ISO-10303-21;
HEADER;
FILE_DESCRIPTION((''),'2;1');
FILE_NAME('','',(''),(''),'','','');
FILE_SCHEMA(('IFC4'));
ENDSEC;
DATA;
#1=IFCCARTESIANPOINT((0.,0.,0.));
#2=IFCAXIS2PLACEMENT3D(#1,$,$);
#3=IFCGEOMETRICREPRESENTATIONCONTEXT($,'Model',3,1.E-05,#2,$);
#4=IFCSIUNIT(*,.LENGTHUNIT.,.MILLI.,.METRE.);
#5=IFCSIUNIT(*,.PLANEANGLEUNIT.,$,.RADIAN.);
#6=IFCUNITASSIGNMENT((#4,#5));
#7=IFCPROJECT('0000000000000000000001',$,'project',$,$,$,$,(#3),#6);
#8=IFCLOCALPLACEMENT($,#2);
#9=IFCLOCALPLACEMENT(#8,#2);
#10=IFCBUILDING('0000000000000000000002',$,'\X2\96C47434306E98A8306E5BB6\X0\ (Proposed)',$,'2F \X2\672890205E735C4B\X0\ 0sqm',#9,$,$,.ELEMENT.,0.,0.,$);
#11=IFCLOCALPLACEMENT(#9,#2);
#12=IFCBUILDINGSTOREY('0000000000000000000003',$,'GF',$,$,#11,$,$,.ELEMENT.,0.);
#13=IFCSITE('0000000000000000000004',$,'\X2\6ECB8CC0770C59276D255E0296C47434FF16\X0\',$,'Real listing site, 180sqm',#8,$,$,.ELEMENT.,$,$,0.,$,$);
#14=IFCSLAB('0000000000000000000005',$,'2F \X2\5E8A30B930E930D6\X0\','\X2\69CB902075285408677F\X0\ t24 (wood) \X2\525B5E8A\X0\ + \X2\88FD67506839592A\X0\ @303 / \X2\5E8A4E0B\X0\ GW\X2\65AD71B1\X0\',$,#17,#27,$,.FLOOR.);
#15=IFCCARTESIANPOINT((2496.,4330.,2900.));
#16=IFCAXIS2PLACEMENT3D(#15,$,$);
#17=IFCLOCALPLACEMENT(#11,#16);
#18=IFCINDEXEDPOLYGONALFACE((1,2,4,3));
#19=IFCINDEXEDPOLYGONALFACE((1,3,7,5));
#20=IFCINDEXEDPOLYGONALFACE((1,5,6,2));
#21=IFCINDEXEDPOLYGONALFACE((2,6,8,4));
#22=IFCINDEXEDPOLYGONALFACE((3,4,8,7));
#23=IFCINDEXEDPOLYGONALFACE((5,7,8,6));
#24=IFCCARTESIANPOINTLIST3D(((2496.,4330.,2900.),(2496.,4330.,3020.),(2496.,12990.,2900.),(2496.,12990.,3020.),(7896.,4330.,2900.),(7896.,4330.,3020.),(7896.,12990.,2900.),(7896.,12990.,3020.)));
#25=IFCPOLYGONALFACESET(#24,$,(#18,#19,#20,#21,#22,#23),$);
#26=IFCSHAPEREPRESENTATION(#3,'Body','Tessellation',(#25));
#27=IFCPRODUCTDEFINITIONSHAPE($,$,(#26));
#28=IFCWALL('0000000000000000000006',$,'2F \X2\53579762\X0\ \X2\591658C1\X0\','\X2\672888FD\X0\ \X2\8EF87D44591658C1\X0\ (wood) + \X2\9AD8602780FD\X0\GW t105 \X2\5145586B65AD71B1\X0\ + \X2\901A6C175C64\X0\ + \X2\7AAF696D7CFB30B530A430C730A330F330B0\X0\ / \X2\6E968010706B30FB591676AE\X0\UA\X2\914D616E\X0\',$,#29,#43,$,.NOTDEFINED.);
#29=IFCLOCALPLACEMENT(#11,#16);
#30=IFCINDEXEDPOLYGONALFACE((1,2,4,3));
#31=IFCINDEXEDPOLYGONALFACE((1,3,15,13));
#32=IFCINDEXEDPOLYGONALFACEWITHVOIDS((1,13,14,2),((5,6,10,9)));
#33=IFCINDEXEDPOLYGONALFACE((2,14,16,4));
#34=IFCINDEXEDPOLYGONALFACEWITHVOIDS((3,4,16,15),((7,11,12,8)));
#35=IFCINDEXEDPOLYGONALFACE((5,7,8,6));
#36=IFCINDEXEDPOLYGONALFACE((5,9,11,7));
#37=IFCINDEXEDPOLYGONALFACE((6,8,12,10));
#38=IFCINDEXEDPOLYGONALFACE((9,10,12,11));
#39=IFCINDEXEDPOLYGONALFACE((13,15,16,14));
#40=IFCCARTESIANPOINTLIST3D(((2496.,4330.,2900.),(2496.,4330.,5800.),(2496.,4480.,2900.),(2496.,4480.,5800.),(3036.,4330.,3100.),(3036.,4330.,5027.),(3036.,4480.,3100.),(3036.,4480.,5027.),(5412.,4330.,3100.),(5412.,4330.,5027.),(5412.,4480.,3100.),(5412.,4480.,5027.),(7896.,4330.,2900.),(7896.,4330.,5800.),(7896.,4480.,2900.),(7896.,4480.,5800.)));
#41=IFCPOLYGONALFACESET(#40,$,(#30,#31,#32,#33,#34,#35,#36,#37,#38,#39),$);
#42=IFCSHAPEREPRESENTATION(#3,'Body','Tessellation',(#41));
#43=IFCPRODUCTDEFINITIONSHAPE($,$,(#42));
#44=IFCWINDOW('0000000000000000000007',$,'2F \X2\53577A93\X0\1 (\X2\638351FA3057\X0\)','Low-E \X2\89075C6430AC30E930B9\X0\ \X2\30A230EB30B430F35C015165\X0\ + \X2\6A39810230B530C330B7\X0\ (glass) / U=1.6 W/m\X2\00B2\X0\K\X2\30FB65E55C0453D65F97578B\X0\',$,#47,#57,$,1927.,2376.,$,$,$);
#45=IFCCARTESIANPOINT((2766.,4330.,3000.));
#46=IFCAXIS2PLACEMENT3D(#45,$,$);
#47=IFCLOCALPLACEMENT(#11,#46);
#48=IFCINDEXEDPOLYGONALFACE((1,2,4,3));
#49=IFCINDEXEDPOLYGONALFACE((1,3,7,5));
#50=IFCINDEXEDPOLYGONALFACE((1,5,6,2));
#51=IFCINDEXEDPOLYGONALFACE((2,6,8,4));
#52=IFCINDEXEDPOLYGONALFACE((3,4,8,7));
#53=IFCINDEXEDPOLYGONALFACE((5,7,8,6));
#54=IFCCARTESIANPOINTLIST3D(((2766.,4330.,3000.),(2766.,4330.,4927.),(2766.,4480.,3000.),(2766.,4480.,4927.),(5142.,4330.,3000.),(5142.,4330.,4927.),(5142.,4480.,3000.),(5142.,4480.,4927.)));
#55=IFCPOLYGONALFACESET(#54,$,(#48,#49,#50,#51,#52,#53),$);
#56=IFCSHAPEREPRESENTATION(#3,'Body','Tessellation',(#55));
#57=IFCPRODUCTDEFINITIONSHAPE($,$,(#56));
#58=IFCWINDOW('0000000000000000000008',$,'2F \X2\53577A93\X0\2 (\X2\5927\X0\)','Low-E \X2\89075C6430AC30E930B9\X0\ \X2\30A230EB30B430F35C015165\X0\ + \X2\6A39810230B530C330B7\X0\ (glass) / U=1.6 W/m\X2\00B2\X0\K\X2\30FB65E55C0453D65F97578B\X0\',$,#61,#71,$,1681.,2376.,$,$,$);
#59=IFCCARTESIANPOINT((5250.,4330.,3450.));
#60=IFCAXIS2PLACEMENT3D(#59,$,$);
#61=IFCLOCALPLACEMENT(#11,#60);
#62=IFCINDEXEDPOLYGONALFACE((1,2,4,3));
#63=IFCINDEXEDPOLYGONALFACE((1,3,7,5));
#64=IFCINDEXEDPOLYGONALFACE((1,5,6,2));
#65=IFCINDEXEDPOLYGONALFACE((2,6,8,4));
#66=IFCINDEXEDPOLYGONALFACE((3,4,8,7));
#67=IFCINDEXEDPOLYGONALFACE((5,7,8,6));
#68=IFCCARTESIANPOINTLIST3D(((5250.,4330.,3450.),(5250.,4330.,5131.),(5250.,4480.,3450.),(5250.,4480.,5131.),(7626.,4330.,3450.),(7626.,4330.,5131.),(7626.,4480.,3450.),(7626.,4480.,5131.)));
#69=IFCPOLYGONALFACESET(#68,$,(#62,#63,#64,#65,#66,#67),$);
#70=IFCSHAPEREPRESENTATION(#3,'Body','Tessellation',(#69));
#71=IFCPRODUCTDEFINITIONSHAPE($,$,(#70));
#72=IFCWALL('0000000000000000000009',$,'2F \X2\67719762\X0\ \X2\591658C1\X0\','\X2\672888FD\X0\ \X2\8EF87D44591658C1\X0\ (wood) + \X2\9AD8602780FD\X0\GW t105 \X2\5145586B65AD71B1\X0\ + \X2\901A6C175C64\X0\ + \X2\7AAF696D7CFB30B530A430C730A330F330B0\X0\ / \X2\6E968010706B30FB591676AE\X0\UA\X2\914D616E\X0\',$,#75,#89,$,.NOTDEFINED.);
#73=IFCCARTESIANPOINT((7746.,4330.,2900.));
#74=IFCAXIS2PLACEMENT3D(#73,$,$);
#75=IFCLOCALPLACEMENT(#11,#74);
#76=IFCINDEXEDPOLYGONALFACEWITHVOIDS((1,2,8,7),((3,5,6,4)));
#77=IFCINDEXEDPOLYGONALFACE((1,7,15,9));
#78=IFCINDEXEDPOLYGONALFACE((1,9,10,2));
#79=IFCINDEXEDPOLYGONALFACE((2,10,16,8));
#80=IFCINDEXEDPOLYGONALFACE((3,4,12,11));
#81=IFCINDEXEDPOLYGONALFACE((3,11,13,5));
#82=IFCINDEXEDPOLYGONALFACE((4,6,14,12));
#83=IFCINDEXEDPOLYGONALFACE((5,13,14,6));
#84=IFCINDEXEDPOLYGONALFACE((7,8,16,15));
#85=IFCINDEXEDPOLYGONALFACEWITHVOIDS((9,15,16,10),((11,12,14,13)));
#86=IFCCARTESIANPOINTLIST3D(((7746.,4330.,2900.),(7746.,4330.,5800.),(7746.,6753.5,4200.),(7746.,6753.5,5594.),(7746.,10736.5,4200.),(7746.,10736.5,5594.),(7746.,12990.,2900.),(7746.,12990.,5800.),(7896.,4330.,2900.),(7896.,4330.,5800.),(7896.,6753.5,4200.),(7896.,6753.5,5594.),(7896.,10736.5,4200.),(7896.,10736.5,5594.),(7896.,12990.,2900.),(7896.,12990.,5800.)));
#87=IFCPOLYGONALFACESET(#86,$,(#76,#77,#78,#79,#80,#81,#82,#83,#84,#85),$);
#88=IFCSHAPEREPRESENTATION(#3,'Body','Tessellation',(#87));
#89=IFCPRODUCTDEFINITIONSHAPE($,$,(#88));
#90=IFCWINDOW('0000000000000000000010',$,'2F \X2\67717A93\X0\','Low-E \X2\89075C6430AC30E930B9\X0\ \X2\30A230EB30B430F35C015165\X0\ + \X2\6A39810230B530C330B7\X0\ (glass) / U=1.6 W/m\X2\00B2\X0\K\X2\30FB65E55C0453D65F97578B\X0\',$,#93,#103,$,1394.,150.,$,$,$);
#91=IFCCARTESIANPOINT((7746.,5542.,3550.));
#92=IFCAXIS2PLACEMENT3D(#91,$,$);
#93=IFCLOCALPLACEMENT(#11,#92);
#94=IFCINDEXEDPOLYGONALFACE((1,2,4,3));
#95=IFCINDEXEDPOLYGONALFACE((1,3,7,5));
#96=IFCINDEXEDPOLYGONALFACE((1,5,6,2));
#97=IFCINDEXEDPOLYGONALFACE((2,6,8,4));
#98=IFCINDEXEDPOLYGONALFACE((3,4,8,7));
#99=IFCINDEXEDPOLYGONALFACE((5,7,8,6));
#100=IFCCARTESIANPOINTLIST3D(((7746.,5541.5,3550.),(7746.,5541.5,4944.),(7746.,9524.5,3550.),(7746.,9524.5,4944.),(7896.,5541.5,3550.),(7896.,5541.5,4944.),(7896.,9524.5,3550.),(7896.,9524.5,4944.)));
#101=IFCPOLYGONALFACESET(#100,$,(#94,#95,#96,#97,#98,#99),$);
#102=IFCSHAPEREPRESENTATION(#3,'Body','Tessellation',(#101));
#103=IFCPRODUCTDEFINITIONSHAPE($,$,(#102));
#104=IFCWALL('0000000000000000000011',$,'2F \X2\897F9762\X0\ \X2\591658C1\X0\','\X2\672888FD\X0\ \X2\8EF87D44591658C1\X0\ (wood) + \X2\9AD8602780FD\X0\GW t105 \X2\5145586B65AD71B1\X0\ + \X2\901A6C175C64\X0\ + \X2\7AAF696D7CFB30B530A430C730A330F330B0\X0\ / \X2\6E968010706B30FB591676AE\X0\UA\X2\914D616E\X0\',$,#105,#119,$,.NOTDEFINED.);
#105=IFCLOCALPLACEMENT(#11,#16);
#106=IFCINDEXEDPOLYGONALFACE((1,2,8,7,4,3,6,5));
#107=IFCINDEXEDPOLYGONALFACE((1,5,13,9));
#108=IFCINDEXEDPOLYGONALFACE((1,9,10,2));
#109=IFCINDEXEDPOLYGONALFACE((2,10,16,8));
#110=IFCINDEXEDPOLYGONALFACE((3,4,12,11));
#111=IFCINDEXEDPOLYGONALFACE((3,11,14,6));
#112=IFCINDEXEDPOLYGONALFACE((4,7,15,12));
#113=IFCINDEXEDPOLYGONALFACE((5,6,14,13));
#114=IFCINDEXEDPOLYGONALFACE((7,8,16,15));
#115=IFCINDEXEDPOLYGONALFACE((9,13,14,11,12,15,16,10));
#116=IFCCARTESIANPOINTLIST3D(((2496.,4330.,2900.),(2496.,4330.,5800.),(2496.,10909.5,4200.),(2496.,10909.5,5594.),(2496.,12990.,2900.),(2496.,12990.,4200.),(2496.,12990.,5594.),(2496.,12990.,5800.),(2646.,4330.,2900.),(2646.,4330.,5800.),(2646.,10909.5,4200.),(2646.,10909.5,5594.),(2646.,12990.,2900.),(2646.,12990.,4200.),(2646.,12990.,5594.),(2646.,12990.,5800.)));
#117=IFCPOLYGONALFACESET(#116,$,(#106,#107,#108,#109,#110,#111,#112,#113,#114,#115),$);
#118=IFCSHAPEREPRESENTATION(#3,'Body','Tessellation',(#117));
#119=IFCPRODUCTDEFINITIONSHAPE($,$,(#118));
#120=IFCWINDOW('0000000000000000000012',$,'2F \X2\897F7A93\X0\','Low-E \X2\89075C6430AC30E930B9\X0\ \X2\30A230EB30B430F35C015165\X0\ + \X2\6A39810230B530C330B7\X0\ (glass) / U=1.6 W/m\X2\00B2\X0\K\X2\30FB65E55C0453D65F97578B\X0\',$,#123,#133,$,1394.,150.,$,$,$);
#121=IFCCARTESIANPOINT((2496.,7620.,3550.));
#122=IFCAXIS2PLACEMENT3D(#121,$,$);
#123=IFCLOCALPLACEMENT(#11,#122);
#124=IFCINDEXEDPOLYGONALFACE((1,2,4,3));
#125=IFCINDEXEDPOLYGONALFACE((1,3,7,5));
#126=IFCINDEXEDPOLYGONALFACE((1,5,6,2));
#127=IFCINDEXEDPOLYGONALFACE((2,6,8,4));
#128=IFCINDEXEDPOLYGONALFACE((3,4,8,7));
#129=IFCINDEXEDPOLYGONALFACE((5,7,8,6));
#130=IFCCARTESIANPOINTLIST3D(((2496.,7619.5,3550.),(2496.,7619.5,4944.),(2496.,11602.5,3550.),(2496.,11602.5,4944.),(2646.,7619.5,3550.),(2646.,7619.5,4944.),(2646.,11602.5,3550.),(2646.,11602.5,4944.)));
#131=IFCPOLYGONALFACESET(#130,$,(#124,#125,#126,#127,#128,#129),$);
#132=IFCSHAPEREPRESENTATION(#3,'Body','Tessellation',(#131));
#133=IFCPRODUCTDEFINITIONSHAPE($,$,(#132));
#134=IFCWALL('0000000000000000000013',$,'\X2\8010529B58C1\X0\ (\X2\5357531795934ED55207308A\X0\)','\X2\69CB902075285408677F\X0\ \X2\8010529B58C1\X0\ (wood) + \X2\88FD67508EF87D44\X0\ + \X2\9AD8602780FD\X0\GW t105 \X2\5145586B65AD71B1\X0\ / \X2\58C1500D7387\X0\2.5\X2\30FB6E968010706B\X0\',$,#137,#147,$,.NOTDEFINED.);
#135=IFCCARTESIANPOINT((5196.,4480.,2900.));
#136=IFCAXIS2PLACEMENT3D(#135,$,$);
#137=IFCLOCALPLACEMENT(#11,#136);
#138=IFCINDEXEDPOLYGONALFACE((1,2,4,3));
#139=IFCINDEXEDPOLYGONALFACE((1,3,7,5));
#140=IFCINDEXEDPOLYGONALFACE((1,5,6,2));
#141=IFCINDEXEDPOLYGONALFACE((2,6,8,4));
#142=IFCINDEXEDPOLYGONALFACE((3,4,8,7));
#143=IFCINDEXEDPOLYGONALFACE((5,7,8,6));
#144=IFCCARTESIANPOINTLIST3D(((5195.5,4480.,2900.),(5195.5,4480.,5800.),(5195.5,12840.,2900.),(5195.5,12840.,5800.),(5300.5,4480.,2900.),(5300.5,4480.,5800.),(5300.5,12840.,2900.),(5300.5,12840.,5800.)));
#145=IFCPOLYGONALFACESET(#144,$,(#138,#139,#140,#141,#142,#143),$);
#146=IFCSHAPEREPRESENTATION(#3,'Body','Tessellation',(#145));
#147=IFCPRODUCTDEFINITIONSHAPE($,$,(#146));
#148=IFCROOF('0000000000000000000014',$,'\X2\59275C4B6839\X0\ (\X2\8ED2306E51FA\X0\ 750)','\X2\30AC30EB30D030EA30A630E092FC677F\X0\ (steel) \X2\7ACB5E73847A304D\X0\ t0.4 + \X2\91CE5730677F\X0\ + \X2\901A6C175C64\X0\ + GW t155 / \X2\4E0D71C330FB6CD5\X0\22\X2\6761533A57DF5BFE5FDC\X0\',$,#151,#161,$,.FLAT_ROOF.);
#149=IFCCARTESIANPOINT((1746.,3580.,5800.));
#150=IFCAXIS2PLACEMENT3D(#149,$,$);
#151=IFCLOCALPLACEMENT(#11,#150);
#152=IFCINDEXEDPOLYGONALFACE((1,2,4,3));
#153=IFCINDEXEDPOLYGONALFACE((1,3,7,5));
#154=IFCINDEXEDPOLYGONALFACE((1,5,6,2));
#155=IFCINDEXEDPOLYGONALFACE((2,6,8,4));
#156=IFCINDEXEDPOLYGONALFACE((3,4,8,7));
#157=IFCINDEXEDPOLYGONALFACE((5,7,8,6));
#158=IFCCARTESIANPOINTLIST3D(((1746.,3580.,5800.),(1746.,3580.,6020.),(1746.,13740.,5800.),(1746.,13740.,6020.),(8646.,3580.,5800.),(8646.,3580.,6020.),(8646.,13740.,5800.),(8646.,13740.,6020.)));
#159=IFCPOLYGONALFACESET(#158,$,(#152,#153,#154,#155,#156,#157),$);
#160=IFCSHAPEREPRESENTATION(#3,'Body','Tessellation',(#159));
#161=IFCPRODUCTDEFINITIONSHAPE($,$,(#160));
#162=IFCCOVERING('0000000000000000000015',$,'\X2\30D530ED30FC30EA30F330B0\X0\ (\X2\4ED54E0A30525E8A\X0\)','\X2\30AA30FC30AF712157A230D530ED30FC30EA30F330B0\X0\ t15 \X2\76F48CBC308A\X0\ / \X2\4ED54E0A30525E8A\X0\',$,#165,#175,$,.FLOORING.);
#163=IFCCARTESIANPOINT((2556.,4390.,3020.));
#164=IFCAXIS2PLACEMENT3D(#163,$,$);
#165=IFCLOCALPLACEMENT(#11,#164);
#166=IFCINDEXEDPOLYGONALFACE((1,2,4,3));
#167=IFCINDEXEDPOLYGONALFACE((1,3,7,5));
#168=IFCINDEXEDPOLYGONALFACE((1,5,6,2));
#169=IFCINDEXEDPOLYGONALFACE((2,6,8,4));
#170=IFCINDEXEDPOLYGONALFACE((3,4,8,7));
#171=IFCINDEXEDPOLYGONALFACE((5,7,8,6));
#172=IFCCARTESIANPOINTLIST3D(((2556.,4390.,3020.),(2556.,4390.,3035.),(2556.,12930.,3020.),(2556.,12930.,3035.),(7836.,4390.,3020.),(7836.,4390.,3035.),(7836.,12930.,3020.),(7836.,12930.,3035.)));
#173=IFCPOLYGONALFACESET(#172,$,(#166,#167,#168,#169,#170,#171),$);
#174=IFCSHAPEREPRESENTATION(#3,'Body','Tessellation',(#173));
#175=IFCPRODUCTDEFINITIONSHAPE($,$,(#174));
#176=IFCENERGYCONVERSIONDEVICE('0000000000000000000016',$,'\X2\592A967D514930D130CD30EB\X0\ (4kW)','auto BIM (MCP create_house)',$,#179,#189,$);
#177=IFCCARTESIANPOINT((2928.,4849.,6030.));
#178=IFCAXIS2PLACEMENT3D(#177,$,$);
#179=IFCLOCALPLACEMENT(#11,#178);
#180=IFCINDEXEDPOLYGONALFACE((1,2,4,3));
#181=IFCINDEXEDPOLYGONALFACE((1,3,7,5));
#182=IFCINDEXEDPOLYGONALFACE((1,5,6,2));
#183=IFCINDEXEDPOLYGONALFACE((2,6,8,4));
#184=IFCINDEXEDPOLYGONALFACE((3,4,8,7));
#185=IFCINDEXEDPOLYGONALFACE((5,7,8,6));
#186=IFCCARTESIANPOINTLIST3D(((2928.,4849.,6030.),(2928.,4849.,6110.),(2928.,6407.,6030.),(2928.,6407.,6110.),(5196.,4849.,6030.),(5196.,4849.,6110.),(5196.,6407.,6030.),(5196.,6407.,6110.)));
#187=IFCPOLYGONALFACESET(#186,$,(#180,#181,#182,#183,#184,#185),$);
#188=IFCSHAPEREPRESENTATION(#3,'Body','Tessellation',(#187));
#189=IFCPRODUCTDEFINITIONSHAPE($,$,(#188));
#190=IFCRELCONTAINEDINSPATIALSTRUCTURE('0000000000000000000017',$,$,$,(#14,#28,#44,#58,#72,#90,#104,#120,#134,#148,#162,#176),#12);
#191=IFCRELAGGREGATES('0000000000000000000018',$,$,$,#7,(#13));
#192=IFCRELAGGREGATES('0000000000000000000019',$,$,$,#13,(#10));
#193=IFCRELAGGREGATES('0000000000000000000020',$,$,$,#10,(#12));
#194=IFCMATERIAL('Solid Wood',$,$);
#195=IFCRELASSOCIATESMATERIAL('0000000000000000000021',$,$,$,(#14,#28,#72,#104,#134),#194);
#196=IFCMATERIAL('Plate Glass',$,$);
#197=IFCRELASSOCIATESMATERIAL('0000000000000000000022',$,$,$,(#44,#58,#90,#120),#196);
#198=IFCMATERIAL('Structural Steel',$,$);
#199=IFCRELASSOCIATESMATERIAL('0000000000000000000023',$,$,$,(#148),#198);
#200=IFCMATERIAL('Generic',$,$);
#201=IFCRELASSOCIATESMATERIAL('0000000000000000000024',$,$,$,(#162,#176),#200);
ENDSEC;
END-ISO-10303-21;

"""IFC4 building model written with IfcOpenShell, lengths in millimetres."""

from ifc_helpers import new_model, si_unit, frame, frame_2d, origin, place, context, project, spatial, rectangle, extrude, material, element, fill, save


model = new_model("IFC4")

# Units and contexts
model_context = context("Model", 3, precision=1e-05, world=origin())
ifc_project = project(units=[si_unit("LENGTHUNIT", "METRE", prefix="MILLI"), si_unit("PLANEANGLEUNIT", "RADIAN")], contexts=[model_context])

# Site, building, storey
site_placement = place(None, origin())
site = spatial("IfcSite", under=ifc_project, at=site_placement, Name="滋賀県大津市雄琴６", ObjectType="Real listing site, 180sqm", CompositionType="ELEMENT", RefElevation=0.0)
building_placement = place(site_placement, origin())
building = spatial("IfcBuilding", under=site, at=building_placement, Name="雄琴の風の家 (Proposed)", ObjectType="2F 木造平屋 0sqm", CompositionType="ELEMENT", ElevationOfRefHeight=0.0, ElevationOfTerrain=0.0)
storey_placement = place(building_placement, origin())
storey = spatial("IfcBuildingStorey", under=building, at=storey_placement, Name="GF", CompositionType="ELEMENT", Elevation=0.0)

# Slab
ifc_material_1 = material(Name="Solid Wood")
slab_placement = place(storey_placement, frame((2496.0, 4330.0, 2900.0)))
element("IfcSlab", 1, at=slab_placement, inside=storey, material=ifc_material_1, Name="2F 床スラブ", Description="構造用合板 t24 (wood) 剛床 + 製材根太 @303 / 床下 GW断熱", PredefinedType="FLOOR", context=model_context, shape_type="SweptSolid", body=[
    extrude(rectangle(XDim=5400.0, YDim=8660.0, at=frame_2d((2700.0, 4330.0))), frame((2496.0, 4330.0, 2900.0)), (0.0, 0.0, 1.0), 120.0),
])

# Wall, openings, windows
wall_1_placement = place(storey_placement, frame((2496.0, 4330.0, 2900.0)))
wall_1 = element("IfcWall", 2, at=wall_1_placement, inside=storey, material=ifc_material_1, Name="2F 南面 外壁", Description="木製 軸組外壁 (wood) + 高性能GW t105 充填断熱 + 通気層 + 窯業系サイディング / 準耐火・外皮UA配慮", PredefinedType="NOTDEFINED", context=model_context, shape_type="SweptSolid", body=[
    extrude(rectangle(XDim=5400.0, YDim=150.0, at=frame_2d((2700.0, 75.0))), frame((2496.0, 4330.0, 2900.0)), (0.0, 0.0, 1.0), 2900.0),
])
opening_1_placement = place(storey_placement, frame((2766.0, 4330.0, 3000.0)))
opening_1 = element("IfcOpeningElement", 3, at=opening_1_placement, cuts=wall_1, PredefinedType="NOTDEFINED", context=model_context, shape_type="SweptSolid", body=[
    extrude(rectangle(XDim=2376.0, YDim=150.0, at=frame_2d((1188.0, 75.0))), frame((2766.0, 4330.0, 3000.0)), (0.0, 0.0, 1.0), 1927.0),
])
opening_2_placement = place(storey_placement, frame((5250.0, 4330.0, 3450.0)))
opening_2 = element("IfcOpeningElement", 4, at=opening_2_placement, cuts=wall_1, PredefinedType="NOTDEFINED", context=model_context, shape_type="SweptSolid", body=[
    extrude(rectangle(XDim=2376.0, YDim=150.0, at=frame_2d((1188.0, 75.0))), frame((5250.0, 4330.0, 3450.0)), (0.0, 0.0, 1.0), 1681.0),
])
ifc_material_2 = material(Name="Plate Glass")
window_1_placement = place(storey_placement, frame((2766.0, 4330.0, 3000.0)))
window_1 = element("IfcWindow", 5, at=window_1_placement, inside=storey, material=ifc_material_2, Name="2F 南窓1 (掃出し)", Description="Low-E 複層ガラス アルゴン封入 + 樹脂サッシ (glass) / U=1.6 W/m²K・日射取得型", OverallHeight=1927.0, OverallWidth=2376.0, context=model_context, shape_type="SweptSolid", body=[
    extrude(rectangle(XDim=2376.0, YDim=150.0, at=frame_2d((1188.0, 75.0))), frame((2766.0, 4330.0, 3000.0)), (0.0, 0.0, 1.0), 1927.0),
])
fill(opening_1, window_1)
window_2_placement = place(storey_placement, frame((5250.0, 4330.0, 3450.0)))
window_2 = element("IfcWindow", 6, at=window_2_placement, inside=storey, material=ifc_material_2, Name="2F 南窓2 (大)", Description="Low-E 複層ガラス アルゴン封入 + 樹脂サッシ (glass) / U=1.6 W/m²K・日射取得型", OverallHeight=1681.0, OverallWidth=2376.0, context=model_context, shape_type="SweptSolid", body=[
    extrude(rectangle(XDim=2376.0, YDim=150.0, at=frame_2d((1188.0, 75.0))), frame((5250.0, 4330.0, 3450.0)), (0.0, 0.0, 1.0), 1681.0),
])
fill(opening_2, window_2)

# Walls, openings, windows
wall_2_placement = place(storey_placement, frame((7746.0, 4330.0, 2900.0)))
wall_2 = element("IfcWall", 7, at=wall_2_placement, inside=storey, material=ifc_material_1, Name="2F 東面 外壁", Description="木製 軸組外壁 (wood) + 高性能GW t105 充填断熱 + 通気層 + 窯業系サイディング / 準耐火・外皮UA配慮", PredefinedType="NOTDEFINED", context=model_context, shape_type="SweptSolid", body=[
    extrude(rectangle(XDim=150.0, YDim=8660.0, at=frame_2d((75.0, 4330.0))), frame((7746.0, 4330.0, 2900.0)), (0.0, 0.0, 1.0), 2900.0),
])
opening_3_placement = place(storey_placement, frame((7746.0, 5542.0, 3550.0)))
opening_3 = element("IfcOpeningElement", 8, at=opening_3_placement, cuts=wall_2, PredefinedType="NOTDEFINED", context=model_context, shape_type="SweptSolid", body=[
    extrude(rectangle(XDim=150.0, YDim=3983.0, at=frame_2d((75.0, 1991.0))), frame((7746.0, 5542.0, 3550.0)), (0.0, 0.0, 1.0), 1394.0),
])
window_3_placement = place(storey_placement, frame((7746.0, 5542.0, 3550.0)))
window_3 = element("IfcWindow", 9, at=window_3_placement, inside=storey, material=ifc_material_2, Name="2F 東窓", Description="Low-E 複層ガラス アルゴン封入 + 樹脂サッシ (glass) / U=1.6 W/m²K・日射取得型", OverallHeight=1394.0, OverallWidth=150.0, context=model_context, shape_type="SweptSolid", body=[
    extrude(rectangle(XDim=150.0, YDim=3983.0, at=frame_2d((75.0, 1991.0))), frame((7746.0, 5542.0, 3550.0)), (0.0, 0.0, 1.0), 1394.0),
])
fill(opening_3, window_3)
wall_3_placement = place(storey_placement, frame((2496.0, 4330.0, 2900.0)))
wall_3 = element("IfcWall", 10, at=wall_3_placement, inside=storey, material=ifc_material_1, Name="2F 西面 外壁", Description="木製 軸組外壁 (wood) + 高性能GW t105 充填断熱 + 通気層 + 窯業系サイディング / 準耐火・外皮UA配慮", PredefinedType="NOTDEFINED", context=model_context, shape_type="SweptSolid", body=[
    extrude(rectangle(XDim=150.0, YDim=8660.0, at=frame_2d((75.0, 4330.0))), frame((2496.0, 4330.0, 2900.0)), (0.0, 0.0, 1.0), 2900.0),
])
opening_4_placement = place(storey_placement, frame((2496.0, 7620.0, 3550.0)))
opening_4 = element("IfcOpeningElement", 11, at=opening_4_placement, cuts=wall_3, PredefinedType="NOTDEFINED", context=model_context, shape_type="SweptSolid", body=[
    extrude(rectangle(XDim=150.0, YDim=3983.0, at=frame_2d((75.0, 1991.0))), frame((2496.0, 7620.0, 3550.0)), (0.0, 0.0, 1.0), 1394.0),
])
window_4_placement = place(storey_placement, frame((2496.0, 7620.0, 3550.0)))
window_4 = element("IfcWindow", 12, at=window_4_placement, inside=storey, material=ifc_material_2, Name="2F 西窓", Description="Low-E 複層ガラス アルゴン封入 + 樹脂サッシ (glass) / U=1.6 W/m²K・日射取得型", OverallHeight=1394.0, OverallWidth=150.0, context=model_context, shape_type="SweptSolid", body=[
    extrude(rectangle(XDim=150.0, YDim=3983.0, at=frame_2d((75.0, 1991.0))), frame((2496.0, 7620.0, 3550.0)), (0.0, 0.0, 1.0), 1394.0),
])
fill(opening_4, window_4)

# Wall
wall_4_placement = place(storey_placement, frame((5196.0, 4480.0, 2900.0)))
element("IfcWall", 13, at=wall_4_placement, inside=storey, material=ifc_material_1, Name="耐力壁 (南北間仕切り)", Description="構造用合板 耐力壁 (wood) + 製材軸組 + 高性能GW t105 充填断熱 / 壁倍率2.5・準耐火", PredefinedType="NOTDEFINED", context=model_context, shape_type="SweptSolid", body=[
    extrude(rectangle(XDim=105.0, YDim=8360.0, at=frame_2d((52.0, 4180.0))), frame((5196.0, 4480.0, 2900.0)), (0.0, 0.0, 1.0), 2900.0),
])

# Roof
ifc_material_3 = material(Name="Structural Steel")
roof_placement = place(storey_placement, frame((1746.0, 3580.0, 5800.0)))
element("IfcRoof", 14, at=roof_placement, inside=storey, material=ifc_material_3, Name="大屋根 (軒の出 750)", Description="ガルバリウム鋼板 (steel) 立平葺き t0.4 + 野地板 + 通気層 + GW t155 / 不燃・法22条区域対応", PredefinedType="FLAT_ROOF", context=model_context, shape_type="SweptSolid", body=[
    extrude(rectangle(XDim=6900.0, YDim=10160.0, at=frame_2d((3450.0, 5080.0))), frame((1746.0, 3580.0, 5800.0)), (0.0, 0.0, 1.0), 220.0),
])

# Covering
ifc_material_4 = material(Name="Generic")
covering_placement = place(storey_placement, frame((2556.0, 4390.0, 3020.0)))
element("IfcCovering", 15, at=covering_placement, inside=storey, material=ifc_material_4, Name="フローリング (仕上げ床)", Description="オーク無垢フローリング t15 直貼り / 仕上げ床", PredefinedType="FLOORING", context=model_context, shape_type="SweptSolid", body=[
    extrude(rectangle(XDim=5280.0, YDim=8540.0, at=frame_2d((2640.0, 4270.0))), frame((2556.0, 4390.0, 3020.0)), (0.0, 0.0, 1.0), 15.0),
])

# Energy conversion device
energy_conversion_device_placement = place(storey_placement, frame((2928.0, 4849.0, 6030.0)))
element("IfcEnergyConversionDevice", 16, at=energy_conversion_device_placement, inside=storey, material=ifc_material_4, Name="太陽光パネル (4kW)", Description="auto BIM (MCP create_house)", context=model_context, shape_type="SweptSolid", body=[
    extrude(rectangle(XDim=2268.0, YDim=1558.0, at=frame_2d((1134.0, 779.0))), frame((2928.0, 4849.0, 6030.0)), (0.0, 0.0, 1.0), 80.0),
])

save(model, "model.ifc")
